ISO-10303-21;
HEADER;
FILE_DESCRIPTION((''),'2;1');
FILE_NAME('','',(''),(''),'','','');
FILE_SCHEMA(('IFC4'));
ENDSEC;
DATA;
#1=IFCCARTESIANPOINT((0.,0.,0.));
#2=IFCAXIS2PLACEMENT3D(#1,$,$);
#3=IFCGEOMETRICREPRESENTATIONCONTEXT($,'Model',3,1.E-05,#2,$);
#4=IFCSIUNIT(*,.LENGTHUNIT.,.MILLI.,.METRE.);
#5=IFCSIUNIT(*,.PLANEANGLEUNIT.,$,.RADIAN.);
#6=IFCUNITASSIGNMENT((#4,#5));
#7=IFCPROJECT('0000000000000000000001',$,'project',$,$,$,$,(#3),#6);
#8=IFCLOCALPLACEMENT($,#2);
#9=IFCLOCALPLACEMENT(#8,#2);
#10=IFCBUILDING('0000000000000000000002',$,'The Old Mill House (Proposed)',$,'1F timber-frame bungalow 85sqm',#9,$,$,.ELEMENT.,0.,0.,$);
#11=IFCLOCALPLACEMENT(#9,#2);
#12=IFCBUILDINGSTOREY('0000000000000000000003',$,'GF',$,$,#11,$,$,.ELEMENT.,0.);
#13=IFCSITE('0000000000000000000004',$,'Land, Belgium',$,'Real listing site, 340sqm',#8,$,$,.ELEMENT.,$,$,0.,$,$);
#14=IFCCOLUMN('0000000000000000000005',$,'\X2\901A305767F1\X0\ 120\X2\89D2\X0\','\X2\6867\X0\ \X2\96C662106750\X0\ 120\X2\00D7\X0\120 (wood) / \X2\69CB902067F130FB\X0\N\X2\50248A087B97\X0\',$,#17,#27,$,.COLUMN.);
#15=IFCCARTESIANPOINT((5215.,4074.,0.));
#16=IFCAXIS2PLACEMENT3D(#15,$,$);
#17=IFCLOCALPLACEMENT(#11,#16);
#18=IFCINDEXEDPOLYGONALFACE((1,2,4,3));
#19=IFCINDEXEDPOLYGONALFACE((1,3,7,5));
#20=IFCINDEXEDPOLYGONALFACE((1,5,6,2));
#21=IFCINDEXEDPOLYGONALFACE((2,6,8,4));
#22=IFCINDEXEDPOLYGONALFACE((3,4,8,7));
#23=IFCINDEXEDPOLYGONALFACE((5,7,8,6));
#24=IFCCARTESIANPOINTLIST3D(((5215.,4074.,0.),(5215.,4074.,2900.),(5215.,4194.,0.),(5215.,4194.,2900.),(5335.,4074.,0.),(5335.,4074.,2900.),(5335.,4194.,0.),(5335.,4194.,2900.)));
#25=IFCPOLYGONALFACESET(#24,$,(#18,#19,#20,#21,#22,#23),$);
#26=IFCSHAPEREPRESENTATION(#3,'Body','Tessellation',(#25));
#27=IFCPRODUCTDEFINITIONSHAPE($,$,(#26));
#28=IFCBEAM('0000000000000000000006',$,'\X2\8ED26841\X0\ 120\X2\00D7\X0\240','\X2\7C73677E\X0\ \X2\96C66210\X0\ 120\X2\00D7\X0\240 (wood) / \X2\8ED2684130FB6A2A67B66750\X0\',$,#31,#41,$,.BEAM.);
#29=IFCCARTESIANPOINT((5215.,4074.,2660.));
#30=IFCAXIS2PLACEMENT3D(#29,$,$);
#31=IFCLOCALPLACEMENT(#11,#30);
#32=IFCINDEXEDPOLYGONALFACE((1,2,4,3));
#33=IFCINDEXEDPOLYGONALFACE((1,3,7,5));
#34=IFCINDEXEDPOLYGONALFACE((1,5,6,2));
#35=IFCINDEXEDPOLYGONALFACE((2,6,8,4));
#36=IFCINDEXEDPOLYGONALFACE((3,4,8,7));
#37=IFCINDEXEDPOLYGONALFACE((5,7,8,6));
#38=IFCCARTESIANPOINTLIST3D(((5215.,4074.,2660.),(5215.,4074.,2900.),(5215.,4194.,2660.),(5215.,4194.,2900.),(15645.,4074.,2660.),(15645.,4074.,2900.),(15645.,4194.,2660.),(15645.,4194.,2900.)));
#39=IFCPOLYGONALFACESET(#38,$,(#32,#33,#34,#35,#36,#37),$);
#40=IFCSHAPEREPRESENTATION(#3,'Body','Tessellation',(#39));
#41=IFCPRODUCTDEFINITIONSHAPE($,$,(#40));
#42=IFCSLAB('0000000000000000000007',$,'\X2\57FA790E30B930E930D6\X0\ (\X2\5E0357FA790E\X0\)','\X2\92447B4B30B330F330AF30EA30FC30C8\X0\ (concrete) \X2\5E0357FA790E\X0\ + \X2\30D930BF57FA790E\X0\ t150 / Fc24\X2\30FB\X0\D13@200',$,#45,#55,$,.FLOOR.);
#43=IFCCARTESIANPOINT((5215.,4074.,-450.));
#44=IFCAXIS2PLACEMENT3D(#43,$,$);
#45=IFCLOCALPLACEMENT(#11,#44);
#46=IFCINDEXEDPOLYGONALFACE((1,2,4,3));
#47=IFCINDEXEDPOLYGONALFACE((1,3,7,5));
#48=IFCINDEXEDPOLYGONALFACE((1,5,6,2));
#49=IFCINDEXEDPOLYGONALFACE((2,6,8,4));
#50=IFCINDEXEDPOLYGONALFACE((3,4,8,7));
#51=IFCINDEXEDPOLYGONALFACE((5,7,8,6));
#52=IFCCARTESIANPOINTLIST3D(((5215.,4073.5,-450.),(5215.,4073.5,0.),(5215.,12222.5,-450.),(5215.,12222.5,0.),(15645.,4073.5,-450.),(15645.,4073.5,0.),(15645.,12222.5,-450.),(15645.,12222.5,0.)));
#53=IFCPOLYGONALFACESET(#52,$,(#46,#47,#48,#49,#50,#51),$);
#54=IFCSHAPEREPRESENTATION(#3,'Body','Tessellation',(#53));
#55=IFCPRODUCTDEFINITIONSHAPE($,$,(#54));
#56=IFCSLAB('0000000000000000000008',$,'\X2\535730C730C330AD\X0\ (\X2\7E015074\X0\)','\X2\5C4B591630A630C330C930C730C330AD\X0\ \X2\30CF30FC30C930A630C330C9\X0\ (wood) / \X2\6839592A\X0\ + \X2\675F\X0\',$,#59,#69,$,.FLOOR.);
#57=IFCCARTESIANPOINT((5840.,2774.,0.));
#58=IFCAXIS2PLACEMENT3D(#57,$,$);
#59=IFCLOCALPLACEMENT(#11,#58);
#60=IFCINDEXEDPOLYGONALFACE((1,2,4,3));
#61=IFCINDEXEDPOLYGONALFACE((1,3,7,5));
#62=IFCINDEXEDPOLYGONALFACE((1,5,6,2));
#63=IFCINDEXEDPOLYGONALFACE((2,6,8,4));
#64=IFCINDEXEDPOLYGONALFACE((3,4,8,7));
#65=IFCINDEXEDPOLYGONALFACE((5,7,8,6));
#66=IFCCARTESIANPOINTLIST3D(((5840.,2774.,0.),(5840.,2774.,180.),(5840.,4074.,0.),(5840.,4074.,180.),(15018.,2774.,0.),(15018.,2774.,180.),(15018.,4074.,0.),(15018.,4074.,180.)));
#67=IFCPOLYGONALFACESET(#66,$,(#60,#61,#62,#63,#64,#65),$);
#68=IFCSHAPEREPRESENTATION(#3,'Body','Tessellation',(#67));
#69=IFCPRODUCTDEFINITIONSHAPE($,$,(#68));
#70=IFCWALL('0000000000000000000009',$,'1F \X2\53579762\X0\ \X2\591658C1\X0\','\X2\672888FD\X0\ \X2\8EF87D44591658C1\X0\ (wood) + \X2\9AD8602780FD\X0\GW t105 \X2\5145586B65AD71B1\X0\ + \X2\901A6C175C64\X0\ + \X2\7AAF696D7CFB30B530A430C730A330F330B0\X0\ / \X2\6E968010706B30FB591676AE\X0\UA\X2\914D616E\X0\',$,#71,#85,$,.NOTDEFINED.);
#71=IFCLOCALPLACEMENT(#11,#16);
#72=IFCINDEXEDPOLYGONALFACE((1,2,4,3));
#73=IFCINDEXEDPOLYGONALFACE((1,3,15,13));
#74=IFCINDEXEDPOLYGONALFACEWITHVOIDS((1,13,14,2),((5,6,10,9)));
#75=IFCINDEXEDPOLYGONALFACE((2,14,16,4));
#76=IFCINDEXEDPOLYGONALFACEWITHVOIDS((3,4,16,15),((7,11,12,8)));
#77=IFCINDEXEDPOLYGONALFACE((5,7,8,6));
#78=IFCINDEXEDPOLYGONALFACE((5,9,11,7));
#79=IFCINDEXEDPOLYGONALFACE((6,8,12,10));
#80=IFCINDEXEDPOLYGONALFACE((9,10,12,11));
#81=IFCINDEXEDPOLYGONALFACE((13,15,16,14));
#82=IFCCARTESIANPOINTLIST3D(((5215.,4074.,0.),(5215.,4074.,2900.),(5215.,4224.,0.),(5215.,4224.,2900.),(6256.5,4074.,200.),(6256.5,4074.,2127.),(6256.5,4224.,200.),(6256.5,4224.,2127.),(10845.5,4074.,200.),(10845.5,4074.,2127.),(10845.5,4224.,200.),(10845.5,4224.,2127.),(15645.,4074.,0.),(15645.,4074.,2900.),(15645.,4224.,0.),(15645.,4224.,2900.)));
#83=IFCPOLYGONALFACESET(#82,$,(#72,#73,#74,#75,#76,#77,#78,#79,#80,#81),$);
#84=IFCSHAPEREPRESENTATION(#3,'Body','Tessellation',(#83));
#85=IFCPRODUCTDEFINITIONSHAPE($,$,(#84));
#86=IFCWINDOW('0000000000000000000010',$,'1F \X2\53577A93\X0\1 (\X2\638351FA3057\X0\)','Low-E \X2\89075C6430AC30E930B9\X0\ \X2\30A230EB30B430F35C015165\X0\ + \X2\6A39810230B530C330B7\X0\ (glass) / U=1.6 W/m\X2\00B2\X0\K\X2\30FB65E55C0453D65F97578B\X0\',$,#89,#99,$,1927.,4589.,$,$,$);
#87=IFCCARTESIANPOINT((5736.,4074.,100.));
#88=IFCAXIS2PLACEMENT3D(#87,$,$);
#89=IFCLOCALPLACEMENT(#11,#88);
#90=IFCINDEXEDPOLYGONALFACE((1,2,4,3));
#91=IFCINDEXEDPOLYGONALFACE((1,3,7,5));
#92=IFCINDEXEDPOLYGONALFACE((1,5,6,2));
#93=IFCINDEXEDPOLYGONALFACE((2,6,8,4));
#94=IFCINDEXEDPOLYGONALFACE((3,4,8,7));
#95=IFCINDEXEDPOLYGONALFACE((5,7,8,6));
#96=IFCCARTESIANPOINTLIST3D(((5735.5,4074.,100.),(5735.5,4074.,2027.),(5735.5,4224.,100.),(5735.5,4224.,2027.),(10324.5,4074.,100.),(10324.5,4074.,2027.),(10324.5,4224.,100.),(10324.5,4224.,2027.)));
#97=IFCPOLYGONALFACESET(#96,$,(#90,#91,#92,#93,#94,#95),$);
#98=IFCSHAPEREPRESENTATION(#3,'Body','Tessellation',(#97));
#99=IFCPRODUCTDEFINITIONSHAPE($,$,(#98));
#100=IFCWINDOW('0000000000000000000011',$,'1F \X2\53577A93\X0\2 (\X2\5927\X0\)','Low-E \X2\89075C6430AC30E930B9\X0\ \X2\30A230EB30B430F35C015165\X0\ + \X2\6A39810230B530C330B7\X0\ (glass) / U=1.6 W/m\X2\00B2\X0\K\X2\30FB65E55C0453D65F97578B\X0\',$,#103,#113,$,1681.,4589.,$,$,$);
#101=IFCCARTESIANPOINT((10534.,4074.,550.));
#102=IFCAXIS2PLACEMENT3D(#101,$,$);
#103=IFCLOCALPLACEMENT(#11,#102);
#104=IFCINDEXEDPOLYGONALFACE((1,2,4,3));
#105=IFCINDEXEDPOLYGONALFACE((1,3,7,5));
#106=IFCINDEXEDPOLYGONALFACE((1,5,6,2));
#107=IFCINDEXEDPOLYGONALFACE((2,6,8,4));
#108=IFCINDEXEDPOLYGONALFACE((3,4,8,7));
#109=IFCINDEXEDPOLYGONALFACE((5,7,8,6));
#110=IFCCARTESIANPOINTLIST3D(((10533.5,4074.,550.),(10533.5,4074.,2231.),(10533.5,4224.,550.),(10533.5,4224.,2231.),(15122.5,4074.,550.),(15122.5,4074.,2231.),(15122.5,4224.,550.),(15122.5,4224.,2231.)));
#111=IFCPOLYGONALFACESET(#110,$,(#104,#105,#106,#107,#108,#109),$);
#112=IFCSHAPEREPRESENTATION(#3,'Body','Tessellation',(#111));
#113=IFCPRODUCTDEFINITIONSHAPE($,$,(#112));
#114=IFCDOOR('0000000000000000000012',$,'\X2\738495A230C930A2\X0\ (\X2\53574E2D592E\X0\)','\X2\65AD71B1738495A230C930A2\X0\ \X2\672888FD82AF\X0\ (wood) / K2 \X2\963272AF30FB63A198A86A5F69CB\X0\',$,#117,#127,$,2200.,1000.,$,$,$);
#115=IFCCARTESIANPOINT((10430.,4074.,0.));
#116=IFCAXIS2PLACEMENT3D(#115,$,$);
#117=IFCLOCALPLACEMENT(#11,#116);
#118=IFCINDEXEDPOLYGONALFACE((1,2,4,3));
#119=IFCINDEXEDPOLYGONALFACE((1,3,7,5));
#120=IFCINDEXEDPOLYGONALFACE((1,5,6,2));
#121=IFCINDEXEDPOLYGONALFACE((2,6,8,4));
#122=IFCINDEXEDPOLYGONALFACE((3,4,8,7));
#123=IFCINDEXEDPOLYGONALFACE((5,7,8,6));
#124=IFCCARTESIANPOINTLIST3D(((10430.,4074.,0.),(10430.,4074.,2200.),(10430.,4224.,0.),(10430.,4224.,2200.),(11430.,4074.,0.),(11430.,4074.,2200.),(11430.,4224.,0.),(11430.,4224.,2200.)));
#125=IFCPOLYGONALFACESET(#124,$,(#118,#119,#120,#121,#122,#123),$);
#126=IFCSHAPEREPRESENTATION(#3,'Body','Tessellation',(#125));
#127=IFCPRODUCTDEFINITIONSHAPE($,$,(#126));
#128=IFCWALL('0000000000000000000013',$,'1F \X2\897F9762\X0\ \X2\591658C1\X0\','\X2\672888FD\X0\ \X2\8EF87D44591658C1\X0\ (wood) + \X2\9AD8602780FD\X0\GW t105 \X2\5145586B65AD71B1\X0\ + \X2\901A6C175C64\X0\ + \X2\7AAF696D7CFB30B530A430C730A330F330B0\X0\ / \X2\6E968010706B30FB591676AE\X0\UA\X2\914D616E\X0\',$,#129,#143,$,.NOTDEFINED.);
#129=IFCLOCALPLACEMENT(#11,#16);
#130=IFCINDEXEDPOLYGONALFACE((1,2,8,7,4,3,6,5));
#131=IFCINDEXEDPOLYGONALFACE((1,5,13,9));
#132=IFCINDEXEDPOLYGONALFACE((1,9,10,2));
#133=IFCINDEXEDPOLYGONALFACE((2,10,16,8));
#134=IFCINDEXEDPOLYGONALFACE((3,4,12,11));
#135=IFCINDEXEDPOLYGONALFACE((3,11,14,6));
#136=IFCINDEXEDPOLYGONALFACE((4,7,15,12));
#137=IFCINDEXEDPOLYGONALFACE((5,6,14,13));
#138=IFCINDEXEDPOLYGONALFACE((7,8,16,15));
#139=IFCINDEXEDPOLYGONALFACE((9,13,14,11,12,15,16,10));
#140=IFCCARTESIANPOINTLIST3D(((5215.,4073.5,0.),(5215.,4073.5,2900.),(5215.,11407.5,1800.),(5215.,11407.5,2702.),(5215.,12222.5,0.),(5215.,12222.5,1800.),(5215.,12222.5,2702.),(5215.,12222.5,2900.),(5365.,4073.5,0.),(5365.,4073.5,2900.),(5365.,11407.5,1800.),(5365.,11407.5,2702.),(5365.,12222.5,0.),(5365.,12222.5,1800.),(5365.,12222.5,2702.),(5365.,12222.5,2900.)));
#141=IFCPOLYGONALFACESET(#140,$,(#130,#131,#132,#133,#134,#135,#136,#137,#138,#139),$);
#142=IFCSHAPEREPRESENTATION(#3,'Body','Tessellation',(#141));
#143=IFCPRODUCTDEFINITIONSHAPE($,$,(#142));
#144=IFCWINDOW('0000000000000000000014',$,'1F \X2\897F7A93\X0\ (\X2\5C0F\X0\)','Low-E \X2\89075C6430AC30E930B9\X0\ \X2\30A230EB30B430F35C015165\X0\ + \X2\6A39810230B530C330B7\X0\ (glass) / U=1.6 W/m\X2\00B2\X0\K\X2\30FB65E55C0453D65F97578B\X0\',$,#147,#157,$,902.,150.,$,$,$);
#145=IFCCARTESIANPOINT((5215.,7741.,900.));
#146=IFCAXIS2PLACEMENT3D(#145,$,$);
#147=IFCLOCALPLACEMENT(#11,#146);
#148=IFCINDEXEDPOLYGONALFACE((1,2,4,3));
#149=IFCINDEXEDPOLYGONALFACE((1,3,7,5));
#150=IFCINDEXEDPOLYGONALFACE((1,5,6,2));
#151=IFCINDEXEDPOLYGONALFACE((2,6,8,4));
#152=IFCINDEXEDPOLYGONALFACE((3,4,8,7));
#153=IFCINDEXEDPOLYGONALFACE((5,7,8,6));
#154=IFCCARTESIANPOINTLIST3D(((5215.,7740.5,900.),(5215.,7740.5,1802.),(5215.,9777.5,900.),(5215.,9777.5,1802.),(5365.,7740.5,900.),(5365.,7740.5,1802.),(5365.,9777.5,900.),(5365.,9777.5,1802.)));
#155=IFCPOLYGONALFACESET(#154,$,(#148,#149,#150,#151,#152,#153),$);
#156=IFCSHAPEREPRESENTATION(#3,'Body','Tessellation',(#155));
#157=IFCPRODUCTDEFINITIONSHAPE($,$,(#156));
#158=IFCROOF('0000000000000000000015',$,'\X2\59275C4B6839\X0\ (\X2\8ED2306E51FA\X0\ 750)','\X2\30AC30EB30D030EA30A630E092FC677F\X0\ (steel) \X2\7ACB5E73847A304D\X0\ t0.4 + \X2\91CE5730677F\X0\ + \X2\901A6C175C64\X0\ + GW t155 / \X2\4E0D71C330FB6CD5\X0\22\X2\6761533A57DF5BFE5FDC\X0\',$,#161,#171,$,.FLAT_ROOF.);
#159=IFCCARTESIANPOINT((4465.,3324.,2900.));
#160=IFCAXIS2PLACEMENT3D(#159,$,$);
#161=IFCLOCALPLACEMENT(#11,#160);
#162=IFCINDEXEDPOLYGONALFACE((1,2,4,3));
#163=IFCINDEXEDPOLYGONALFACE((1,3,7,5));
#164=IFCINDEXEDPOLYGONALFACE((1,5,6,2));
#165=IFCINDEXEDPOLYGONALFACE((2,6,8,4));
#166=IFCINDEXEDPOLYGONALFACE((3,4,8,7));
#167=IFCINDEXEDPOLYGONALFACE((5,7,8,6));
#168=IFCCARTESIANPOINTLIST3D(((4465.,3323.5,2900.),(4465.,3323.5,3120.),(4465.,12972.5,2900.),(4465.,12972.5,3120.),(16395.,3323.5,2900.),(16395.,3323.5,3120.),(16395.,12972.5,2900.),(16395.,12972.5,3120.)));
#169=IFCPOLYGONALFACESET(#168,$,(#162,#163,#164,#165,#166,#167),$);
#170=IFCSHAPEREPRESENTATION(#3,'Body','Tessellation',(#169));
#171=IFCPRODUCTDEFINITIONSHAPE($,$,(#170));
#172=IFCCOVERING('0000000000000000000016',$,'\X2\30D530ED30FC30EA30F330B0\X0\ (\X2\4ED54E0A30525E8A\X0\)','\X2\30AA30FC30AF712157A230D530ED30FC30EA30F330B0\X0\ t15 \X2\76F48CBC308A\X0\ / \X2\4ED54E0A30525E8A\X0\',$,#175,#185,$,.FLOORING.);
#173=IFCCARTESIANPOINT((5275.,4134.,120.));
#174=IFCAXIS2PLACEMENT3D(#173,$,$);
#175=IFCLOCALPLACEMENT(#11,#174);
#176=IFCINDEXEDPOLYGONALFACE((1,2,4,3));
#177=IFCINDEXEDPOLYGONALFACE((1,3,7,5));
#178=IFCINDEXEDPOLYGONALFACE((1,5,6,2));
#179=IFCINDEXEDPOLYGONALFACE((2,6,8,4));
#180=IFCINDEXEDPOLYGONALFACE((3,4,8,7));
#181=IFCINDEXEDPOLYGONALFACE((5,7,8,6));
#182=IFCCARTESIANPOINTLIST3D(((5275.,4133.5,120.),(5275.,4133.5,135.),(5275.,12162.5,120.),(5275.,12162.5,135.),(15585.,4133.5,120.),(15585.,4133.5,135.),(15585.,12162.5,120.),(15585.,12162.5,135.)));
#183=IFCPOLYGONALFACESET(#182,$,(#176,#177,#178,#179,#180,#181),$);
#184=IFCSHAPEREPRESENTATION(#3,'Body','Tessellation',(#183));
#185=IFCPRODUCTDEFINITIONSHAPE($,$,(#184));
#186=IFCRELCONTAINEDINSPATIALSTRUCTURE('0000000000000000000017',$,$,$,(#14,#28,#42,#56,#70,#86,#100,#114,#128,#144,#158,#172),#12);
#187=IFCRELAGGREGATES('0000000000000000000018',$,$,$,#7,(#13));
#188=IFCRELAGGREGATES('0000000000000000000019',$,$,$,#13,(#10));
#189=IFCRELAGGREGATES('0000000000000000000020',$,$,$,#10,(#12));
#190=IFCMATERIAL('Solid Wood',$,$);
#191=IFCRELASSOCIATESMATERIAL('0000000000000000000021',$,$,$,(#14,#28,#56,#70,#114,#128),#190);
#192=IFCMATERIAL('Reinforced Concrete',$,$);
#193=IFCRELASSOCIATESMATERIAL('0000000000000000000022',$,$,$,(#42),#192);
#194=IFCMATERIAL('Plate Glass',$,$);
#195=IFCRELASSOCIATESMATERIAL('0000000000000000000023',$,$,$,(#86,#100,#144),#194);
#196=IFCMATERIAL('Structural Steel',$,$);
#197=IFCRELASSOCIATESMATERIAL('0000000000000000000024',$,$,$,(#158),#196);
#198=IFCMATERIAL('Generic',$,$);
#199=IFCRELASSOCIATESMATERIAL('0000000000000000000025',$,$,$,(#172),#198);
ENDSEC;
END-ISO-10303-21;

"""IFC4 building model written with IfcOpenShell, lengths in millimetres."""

from ifc_helpers import new_model, si_unit, frame, frame_2d, origin, place, context, project, spatial, rectangle, extrude, material, element, fill, save


model = new_model("IFC4")

# Units and contexts
model_context = context("Model", 3, precision=1e-05, world=origin())
ifc_project = project(units=[si_unit("LENGTHUNIT", "METRE", prefix="MILLI"), si_unit("PLANEANGLEUNIT", "RADIAN")], contexts=[model_context])

# Site, building, storey
site_placement = place(None, origin())
site = spatial("IfcSite", under=ifc_project, at=site_placement, Name="Land, Belgium", ObjectType="Real listing site, 340sqm", CompositionType="ELEMENT", RefElevation=0.0)
building_placement = place(site_placement, origin())
building = spatial("IfcBuilding", under=site, at=building_placement, Name="The Old Mill House (Proposed)", ObjectType="1F timber-frame bungalow 85sqm", CompositionType="ELEMENT", ElevationOfRefHeight=0.0, ElevationOfTerrain=0.0)
storey_placement = place(building_placement, origin())
storey = spatial("IfcBuildingStorey", under=building, at=storey_placement, Name="GF", CompositionType="ELEMENT", Elevation=0.0)

# Column
ifc_material_1 = material(Name="Solid Wood")
column_1_placement = place(storey_placement, frame((5215.0, 4074.0, 0.0)))
element("IfcColumn", 1, at=column_1_placement, inside=storey, material=ifc_material_1, Name="通し柱 120角", Description="桧 集成材 120×120 (wood) / 構造柱・N値計算", PredefinedType="COLUMN", context=model_context, shape_type="SweptSolid", body=[
    extrude(rectangle(XDim=120.0, YDim=120.0, at=frame_2d((60.0, 60.0))), frame((5215.0, 4074.0, 0.0)), (0.0, 0.0, 1.0), 2900.0),
])

# Beam
beam_1_placement = place(storey_placement, frame((5215.0, 4074.0, 2660.0)))
element("IfcBeam", 2, at=beam_1_placement, inside=storey, material=ifc_material_1, Name="軒桁 120×240", Description="米松 集成 120×240 (wood) / 軒桁・横架材", PredefinedType="BEAM", context=model_context, shape_type="SweptSolid", body=[
    extrude(rectangle(XDim=10430.0, YDim=120.0, at=frame_2d((5215.0, 60.0))), frame((5215.0, 4074.0, 2660.0)), (0.0, 0.0, 1.0), 240.0),
])

# Slabs
ifc_material_2 = material(Name="Reinforced Concrete")
slab_1_placement = place(storey_placement, frame((5215.0, 4074.0, -450.0)))
element("IfcSlab", 3, at=slab_1_placement, inside=storey, material=ifc_material_2, Name="基礎スラブ (布基礎)", Description="鉄筋コンクリート (concrete) 布基礎 + ベタ基礎 t150 / Fc24・D13@200", PredefinedType="FLOOR", context=model_context, shape_type="SweptSolid", body=[
    extrude(rectangle(XDim=10430.0, YDim=8149.0, at=frame_2d((5215.0, 4074.0))), frame((5215.0, 4074.0, -450.0)), (0.0, 0.0, 1.0), 450.0),
])
slab_2_placement = place(storey_placement, frame((5840.0, 2774.0, 0.0)))
element("IfcSlab", 4, at=slab_2_placement, inside=storey, material=ifc_material_1, Name="南デッキ (縁側)", Description="屋外ウッドデッキ ハードウッド (wood) / 根太 + 束", PredefinedType="FLOOR", context=model_context, shape_type="SweptSolid", body=[
    extrude(rectangle(XDim=9178.0, YDim=1300.0, at=frame_2d((4589.0, 650.0))), frame((5840.0, 2774.0, 0.0)), (0.0, 0.0, 1.0), 180.0),
])

# Wall, openings, windows, door
wall_1_placement = place(storey_placement, frame((5215.0, 4074.0, 0.0)))
wall_1 = element("IfcWall", 5, at=wall_1_placement, inside=storey, material=ifc_material_1, Name="1F 南面 外壁", Description="木製 軸組外壁 (wood) + 高性能GW t105 充填断熱 + 通気層 + 窯業系サイディング / 準耐火・外皮UA配慮", PredefinedType="NOTDEFINED", context=model_context, shape_type="SweptSolid", body=[
    extrude(rectangle(XDim=10430.0, YDim=150.0, at=frame_2d((5215.0, 75.0))), frame((5215.0, 4074.0, 0.0)), (0.0, 0.0, 1.0), 2900.0),
])
opening_1_placement = place(storey_placement, frame((5736.0, 4074.0, 100.0)))
opening_1 = element("IfcOpeningElement", 6, at=opening_1_placement, cuts=wall_1, PredefinedType="NOTDEFINED", context=model_context, shape_type="SweptSolid", body=[
    extrude(rectangle(XDim=4589.0, YDim=150.0, at=frame_2d((2294.0, 75.0))), frame((5736.0, 4074.0, 100.0)), (0.0, 0.0, 1.0), 1927.0),
])
opening_2_placement = place(storey_placement, frame((10534.0, 4074.0, 550.0)))
opening_2 = element("IfcOpeningElement", 7, at=opening_2_placement, cuts=wall_1, PredefinedType="NOTDEFINED", context=model_context, shape_type="SweptSolid", body=[
    extrude(rectangle(XDim=4589.0, YDim=150.0, at=frame_2d((2294.0, 75.0))), frame((10534.0, 4074.0, 550.0)), (0.0, 0.0, 1.0), 1681.0),
])
opening_3_placement = place(storey_placement, frame((10430.0, 4074.0, 0.0)))
opening_3 = element("IfcOpeningElement", 8, at=opening_3_placement, cuts=wall_1, PredefinedType="NOTDEFINED", context=model_context, shape_type="SweptSolid", body=[
    extrude(rectangle(XDim=1000.0, YDim=150.0, at=frame_2d((500.0, 75.0))), frame((10430.0, 4074.0, 0.0)), (0.0, 0.0, 1.0), 2200.0),
])
ifc_material_3 = material(Name="Plate Glass")
window_1_placement = place(storey_placement, frame((5736.0, 4074.0, 100.0)))
window_1 = element("IfcWindow", 9, at=window_1_placement, inside=storey, material=ifc_material_3, Name="1F 南窓1 (掃出し)", Description="Low-E 複層ガラス アルゴン封入 + 樹脂サッシ (glass) / U=1.6 W/m²K・日射取得型", OverallHeight=1927.0, OverallWidth=4589.0, context=model_context, shape_type="SweptSolid", body=[
    extrude(rectangle(XDim=4589.0, YDim=150.0, at=frame_2d((2294.0, 75.0))), frame((5736.0, 4074.0, 100.0)), (0.0, 0.0, 1.0), 1927.0),
])
fill(opening_1, window_1)
window_2_placement = place(storey_placement, frame((10534.0, 4074.0, 550.0)))
window_2 = element("IfcWindow", 10, at=window_2_placement, inside=storey, material=ifc_material_3, Name="1F 南窓2 (大)", Description="Low-E 複層ガラス アルゴン封入 + 樹脂サッシ (glass) / U=1.6 W/m²K・日射取得型", OverallHeight=1681.0, OverallWidth=4589.0, context=model_context, shape_type="SweptSolid", body=[
    extrude(rectangle(XDim=4589.0, YDim=150.0, at=frame_2d((2294.0, 75.0))), frame((10534.0, 4074.0, 550.0)), (0.0, 0.0, 1.0), 1681.0),
])
fill(opening_2, window_2)
door_placement = place(storey_placement, frame((10430.0, 4074.0, 0.0)))
door = element("IfcDoor", 11, at=door_placement, inside=storey, material=ifc_material_1, Name="玄関ドア (南中央)", Description="断熱玄関ドア 木製芯 (wood) / K2 防犯・採風機構", OverallHeight=2200.0, OverallWidth=1000.0, context=model_context, shape_type="SweptSolid", body=[
    extrude(rectangle(XDim=1000.0, YDim=150.0, at=frame_2d((500.0, 75.0))), frame((10430.0, 4074.0, 0.0)), (0.0, 0.0, 1.0), 2200.0),
])
fill(opening_3, door)

# Wall, opening, window
wall_2_placement = place(storey_placement, frame((5215.0, 4074.0, 0.0)))
wall_2 = element("IfcWall", 12, at=wall_2_placement, inside=storey, material=ifc_material_1, Name="1F 西面 外壁", Description="木製 軸組外壁 (wood) + 高性能GW t105 充填断熱 + 通気層 + 窯業系サイディング / 準耐火・外皮UA配慮", PredefinedType="NOTDEFINED", context=model_context, shape_type="SweptSolid", body=[
    extrude(rectangle(XDim=150.0, YDim=8149.0, at=frame_2d((75.0, 4074.0))), frame((5215.0, 4074.0, 0.0)), (0.0, 0.0, 1.0), 2900.0),
])
opening_4_placement = place(storey_placement, frame((5215.0, 7741.0, 900.0)))
opening_4 = element("IfcOpeningElement", 13, at=opening_4_placement, cuts=wall_2, PredefinedType="NOTDEFINED", context=model_context, shape_type="SweptSolid", body=[
    extrude(rectangle(XDim=150.0, YDim=2037.0, at=frame_2d((75.0, 1018.0))), frame((5215.0, 7741.0, 900.0)), (0.0, 0.0, 1.0), 902.0),
])
window_3_placement = place(storey_placement, frame((5215.0, 7741.0, 900.0)))
window_3 = element("IfcWindow", 14, at=window_3_placement, inside=storey, material=ifc_material_3, Name="1F 西窓 (小)", Description="Low-E 複層ガラス アルゴン封入 + 樹脂サッシ (glass) / U=1.6 W/m²K・日射取得型", OverallHeight=902.0, OverallWidth=150.0, context=model_context, shape_type="SweptSolid", body=[
    extrude(rectangle(XDim=150.0, YDim=2037.0, at=frame_2d((75.0, 1018.0))), frame((5215.0, 7741.0, 900.0)), (0.0, 0.0, 1.0), 902.0),
])
fill(opening_4, window_3)

# Roof
ifc_material_4 = material(Name="Structural Steel")
roof_placement = place(storey_placement, frame((4465.0, 3324.0, 2900.0)))
element("IfcRoof", 15, at=roof_placement, inside=storey, material=ifc_material_4, Name="大屋根 (軒の出 750)", Description="ガルバリウム鋼板 (steel) 立平葺き t0.4 + 野地板 + 通気層 + GW t155 / 不燃・法22条区域対応", PredefinedType="FLAT_ROOF", context=model_context, shape_type="SweptSolid", body=[
    extrude(rectangle(XDim=11930.0, YDim=9649.0, at=frame_2d((5965.0, 4824.0))), frame((4465.0, 3324.0, 2900.0)), (0.0, 0.0, 1.0), 220.0),
])

# Covering
ifc_material_5 = material(Name="Generic")
covering_1_placement = place(storey_placement, frame((5275.0, 4134.0, 120.0)))
element("IfcCovering", 16, at=covering_1_placement, inside=storey, material=ifc_material_5, Name="フローリング (仕上げ床)", Description="オーク無垢フローリング t15 直貼り / 仕上げ床", PredefinedType="FLOORING", context=model_context, shape_type="SweptSolid", body=[
    extrude(rectangle(XDim=10310.0, YDim=8029.0, at=frame_2d((5155.0, 4014.0))), frame((5275.0, 4134.0, 120.0)), (0.0, 0.0, 1.0), 15.0),
])

save(model, "model.ifc")
